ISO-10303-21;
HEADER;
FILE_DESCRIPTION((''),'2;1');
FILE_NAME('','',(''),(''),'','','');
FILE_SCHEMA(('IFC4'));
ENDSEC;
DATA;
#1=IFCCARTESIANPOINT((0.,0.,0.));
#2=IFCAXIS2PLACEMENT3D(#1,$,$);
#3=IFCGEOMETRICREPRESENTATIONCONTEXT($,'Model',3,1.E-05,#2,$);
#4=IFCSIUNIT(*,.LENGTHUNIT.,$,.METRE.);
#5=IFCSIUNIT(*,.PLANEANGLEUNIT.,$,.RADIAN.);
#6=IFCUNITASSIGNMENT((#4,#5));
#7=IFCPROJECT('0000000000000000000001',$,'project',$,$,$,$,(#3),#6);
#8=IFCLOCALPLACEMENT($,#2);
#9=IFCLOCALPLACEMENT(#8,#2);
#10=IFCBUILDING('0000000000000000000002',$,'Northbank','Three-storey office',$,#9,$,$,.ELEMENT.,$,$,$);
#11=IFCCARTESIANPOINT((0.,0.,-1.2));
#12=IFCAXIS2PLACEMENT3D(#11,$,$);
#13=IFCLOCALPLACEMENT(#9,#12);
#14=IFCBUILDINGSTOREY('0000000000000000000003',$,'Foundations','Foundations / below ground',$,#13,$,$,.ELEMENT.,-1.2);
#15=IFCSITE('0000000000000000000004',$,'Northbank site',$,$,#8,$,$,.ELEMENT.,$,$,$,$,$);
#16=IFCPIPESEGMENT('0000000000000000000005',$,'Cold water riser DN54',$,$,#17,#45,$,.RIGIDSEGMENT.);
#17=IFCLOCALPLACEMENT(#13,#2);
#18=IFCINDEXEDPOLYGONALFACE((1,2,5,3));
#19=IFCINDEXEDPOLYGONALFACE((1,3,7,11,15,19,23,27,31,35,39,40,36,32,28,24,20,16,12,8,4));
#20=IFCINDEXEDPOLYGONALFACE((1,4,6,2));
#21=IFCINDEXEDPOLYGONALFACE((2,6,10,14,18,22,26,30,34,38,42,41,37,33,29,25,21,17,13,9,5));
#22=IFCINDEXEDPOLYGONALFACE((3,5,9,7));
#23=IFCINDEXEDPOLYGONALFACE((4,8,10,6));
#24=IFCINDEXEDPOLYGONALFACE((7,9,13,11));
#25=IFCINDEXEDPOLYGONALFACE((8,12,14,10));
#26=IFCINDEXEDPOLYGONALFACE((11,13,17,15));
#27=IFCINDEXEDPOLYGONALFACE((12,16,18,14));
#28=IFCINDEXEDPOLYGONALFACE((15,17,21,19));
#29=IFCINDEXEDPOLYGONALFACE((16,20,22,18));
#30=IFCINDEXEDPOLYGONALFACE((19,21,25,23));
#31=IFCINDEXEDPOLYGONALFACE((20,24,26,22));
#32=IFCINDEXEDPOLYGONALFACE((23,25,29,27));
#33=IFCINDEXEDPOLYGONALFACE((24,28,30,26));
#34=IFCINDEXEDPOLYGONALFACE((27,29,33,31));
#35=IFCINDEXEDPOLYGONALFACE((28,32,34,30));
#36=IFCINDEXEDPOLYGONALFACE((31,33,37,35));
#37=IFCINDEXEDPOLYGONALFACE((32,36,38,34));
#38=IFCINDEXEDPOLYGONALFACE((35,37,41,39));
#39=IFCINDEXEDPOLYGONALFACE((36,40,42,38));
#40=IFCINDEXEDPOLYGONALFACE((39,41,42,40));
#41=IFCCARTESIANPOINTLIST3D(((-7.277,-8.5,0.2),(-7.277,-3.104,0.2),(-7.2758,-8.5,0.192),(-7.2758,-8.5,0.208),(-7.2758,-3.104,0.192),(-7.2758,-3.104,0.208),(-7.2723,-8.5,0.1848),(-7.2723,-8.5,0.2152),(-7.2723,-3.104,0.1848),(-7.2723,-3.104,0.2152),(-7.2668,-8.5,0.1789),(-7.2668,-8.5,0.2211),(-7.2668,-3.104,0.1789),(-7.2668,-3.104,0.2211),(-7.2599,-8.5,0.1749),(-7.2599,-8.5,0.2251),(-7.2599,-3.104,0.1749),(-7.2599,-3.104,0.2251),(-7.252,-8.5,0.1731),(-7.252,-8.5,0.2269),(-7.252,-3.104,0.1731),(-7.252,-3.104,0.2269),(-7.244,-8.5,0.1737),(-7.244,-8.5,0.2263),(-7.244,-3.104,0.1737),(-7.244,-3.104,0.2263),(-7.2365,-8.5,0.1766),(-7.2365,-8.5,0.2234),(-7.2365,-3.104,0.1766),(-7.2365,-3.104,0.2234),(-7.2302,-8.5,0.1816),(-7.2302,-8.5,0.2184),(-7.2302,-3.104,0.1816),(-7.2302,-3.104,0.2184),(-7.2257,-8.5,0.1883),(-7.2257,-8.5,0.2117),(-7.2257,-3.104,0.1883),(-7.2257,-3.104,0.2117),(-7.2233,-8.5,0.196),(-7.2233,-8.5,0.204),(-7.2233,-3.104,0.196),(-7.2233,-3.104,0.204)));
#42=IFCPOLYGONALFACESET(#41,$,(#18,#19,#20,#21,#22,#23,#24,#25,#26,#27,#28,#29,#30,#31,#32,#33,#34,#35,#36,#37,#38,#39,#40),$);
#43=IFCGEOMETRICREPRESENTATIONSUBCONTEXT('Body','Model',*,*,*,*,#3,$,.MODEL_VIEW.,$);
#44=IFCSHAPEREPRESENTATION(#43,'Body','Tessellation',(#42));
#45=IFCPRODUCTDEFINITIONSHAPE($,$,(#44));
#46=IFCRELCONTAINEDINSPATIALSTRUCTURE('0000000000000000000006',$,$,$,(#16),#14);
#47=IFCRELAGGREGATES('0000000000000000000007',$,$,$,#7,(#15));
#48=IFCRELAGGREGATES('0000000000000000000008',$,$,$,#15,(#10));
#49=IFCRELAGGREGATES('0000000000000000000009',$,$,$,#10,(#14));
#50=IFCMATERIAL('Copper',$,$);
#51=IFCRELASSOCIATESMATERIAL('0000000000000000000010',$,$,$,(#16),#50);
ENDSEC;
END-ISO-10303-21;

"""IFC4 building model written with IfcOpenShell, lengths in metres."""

from ifc_helpers import new_model, si_unit, frame, origin, place, context, subcontext, project, spatial, circle, extrude, material, element, save


model = new_model("IFC4")

# Units and contexts
model_context = context("Model", 3, precision=1e-05, world=origin())
body_context = subcontext(model_context, "Body", "Model", "MODEL_VIEW")
ifc_project = project(units=[si_unit("LENGTHUNIT", "METRE"), si_unit("PLANEANGLEUNIT", "RADIAN")], contexts=[model_context])

# Site, building, storey
site_placement = place(None, origin())
site = spatial("IfcSite", under=ifc_project, at=site_placement, Name="Northbank site", CompositionType="ELEMENT")
building_placement = place(site_placement, origin())
building = spatial("IfcBuilding", under=site, at=building_placement, Name="Northbank", Description="Three-storey office", CompositionType="ELEMENT")
storey_placement = place(building_placement, frame((0.0, 0.0, -1.2)))
storey = spatial("IfcBuildingStorey", under=building, at=storey_placement, Name="Foundations", Description="Foundations / below ground", CompositionType="ELEMENT", Elevation=-1.2)

# Pipe segment
ifc_material_1 = material(Name="Copper")
pipe_segment_1_placement = place(storey_placement, frame((0.0, 0.0, 1.2)))
element("IfcPipeSegment", 1, at=pipe_segment_1_placement, inside=storey, material=ifc_material_1, Name="Cold water riser DN54", PredefinedType="RIGIDSEGMENT", context=body_context, shape_type="SweptSolid", body=[
    extrude(circle(Radius=0.027), frame((-7.25, -8.5, -1.0), z_axis=(0.0, 1.0, 0.0), x_axis=(-1.0, 0.0, 0.0)), (0.0, 0.0, 1.0), 5.396),
])

save(model, "model.ifc")
